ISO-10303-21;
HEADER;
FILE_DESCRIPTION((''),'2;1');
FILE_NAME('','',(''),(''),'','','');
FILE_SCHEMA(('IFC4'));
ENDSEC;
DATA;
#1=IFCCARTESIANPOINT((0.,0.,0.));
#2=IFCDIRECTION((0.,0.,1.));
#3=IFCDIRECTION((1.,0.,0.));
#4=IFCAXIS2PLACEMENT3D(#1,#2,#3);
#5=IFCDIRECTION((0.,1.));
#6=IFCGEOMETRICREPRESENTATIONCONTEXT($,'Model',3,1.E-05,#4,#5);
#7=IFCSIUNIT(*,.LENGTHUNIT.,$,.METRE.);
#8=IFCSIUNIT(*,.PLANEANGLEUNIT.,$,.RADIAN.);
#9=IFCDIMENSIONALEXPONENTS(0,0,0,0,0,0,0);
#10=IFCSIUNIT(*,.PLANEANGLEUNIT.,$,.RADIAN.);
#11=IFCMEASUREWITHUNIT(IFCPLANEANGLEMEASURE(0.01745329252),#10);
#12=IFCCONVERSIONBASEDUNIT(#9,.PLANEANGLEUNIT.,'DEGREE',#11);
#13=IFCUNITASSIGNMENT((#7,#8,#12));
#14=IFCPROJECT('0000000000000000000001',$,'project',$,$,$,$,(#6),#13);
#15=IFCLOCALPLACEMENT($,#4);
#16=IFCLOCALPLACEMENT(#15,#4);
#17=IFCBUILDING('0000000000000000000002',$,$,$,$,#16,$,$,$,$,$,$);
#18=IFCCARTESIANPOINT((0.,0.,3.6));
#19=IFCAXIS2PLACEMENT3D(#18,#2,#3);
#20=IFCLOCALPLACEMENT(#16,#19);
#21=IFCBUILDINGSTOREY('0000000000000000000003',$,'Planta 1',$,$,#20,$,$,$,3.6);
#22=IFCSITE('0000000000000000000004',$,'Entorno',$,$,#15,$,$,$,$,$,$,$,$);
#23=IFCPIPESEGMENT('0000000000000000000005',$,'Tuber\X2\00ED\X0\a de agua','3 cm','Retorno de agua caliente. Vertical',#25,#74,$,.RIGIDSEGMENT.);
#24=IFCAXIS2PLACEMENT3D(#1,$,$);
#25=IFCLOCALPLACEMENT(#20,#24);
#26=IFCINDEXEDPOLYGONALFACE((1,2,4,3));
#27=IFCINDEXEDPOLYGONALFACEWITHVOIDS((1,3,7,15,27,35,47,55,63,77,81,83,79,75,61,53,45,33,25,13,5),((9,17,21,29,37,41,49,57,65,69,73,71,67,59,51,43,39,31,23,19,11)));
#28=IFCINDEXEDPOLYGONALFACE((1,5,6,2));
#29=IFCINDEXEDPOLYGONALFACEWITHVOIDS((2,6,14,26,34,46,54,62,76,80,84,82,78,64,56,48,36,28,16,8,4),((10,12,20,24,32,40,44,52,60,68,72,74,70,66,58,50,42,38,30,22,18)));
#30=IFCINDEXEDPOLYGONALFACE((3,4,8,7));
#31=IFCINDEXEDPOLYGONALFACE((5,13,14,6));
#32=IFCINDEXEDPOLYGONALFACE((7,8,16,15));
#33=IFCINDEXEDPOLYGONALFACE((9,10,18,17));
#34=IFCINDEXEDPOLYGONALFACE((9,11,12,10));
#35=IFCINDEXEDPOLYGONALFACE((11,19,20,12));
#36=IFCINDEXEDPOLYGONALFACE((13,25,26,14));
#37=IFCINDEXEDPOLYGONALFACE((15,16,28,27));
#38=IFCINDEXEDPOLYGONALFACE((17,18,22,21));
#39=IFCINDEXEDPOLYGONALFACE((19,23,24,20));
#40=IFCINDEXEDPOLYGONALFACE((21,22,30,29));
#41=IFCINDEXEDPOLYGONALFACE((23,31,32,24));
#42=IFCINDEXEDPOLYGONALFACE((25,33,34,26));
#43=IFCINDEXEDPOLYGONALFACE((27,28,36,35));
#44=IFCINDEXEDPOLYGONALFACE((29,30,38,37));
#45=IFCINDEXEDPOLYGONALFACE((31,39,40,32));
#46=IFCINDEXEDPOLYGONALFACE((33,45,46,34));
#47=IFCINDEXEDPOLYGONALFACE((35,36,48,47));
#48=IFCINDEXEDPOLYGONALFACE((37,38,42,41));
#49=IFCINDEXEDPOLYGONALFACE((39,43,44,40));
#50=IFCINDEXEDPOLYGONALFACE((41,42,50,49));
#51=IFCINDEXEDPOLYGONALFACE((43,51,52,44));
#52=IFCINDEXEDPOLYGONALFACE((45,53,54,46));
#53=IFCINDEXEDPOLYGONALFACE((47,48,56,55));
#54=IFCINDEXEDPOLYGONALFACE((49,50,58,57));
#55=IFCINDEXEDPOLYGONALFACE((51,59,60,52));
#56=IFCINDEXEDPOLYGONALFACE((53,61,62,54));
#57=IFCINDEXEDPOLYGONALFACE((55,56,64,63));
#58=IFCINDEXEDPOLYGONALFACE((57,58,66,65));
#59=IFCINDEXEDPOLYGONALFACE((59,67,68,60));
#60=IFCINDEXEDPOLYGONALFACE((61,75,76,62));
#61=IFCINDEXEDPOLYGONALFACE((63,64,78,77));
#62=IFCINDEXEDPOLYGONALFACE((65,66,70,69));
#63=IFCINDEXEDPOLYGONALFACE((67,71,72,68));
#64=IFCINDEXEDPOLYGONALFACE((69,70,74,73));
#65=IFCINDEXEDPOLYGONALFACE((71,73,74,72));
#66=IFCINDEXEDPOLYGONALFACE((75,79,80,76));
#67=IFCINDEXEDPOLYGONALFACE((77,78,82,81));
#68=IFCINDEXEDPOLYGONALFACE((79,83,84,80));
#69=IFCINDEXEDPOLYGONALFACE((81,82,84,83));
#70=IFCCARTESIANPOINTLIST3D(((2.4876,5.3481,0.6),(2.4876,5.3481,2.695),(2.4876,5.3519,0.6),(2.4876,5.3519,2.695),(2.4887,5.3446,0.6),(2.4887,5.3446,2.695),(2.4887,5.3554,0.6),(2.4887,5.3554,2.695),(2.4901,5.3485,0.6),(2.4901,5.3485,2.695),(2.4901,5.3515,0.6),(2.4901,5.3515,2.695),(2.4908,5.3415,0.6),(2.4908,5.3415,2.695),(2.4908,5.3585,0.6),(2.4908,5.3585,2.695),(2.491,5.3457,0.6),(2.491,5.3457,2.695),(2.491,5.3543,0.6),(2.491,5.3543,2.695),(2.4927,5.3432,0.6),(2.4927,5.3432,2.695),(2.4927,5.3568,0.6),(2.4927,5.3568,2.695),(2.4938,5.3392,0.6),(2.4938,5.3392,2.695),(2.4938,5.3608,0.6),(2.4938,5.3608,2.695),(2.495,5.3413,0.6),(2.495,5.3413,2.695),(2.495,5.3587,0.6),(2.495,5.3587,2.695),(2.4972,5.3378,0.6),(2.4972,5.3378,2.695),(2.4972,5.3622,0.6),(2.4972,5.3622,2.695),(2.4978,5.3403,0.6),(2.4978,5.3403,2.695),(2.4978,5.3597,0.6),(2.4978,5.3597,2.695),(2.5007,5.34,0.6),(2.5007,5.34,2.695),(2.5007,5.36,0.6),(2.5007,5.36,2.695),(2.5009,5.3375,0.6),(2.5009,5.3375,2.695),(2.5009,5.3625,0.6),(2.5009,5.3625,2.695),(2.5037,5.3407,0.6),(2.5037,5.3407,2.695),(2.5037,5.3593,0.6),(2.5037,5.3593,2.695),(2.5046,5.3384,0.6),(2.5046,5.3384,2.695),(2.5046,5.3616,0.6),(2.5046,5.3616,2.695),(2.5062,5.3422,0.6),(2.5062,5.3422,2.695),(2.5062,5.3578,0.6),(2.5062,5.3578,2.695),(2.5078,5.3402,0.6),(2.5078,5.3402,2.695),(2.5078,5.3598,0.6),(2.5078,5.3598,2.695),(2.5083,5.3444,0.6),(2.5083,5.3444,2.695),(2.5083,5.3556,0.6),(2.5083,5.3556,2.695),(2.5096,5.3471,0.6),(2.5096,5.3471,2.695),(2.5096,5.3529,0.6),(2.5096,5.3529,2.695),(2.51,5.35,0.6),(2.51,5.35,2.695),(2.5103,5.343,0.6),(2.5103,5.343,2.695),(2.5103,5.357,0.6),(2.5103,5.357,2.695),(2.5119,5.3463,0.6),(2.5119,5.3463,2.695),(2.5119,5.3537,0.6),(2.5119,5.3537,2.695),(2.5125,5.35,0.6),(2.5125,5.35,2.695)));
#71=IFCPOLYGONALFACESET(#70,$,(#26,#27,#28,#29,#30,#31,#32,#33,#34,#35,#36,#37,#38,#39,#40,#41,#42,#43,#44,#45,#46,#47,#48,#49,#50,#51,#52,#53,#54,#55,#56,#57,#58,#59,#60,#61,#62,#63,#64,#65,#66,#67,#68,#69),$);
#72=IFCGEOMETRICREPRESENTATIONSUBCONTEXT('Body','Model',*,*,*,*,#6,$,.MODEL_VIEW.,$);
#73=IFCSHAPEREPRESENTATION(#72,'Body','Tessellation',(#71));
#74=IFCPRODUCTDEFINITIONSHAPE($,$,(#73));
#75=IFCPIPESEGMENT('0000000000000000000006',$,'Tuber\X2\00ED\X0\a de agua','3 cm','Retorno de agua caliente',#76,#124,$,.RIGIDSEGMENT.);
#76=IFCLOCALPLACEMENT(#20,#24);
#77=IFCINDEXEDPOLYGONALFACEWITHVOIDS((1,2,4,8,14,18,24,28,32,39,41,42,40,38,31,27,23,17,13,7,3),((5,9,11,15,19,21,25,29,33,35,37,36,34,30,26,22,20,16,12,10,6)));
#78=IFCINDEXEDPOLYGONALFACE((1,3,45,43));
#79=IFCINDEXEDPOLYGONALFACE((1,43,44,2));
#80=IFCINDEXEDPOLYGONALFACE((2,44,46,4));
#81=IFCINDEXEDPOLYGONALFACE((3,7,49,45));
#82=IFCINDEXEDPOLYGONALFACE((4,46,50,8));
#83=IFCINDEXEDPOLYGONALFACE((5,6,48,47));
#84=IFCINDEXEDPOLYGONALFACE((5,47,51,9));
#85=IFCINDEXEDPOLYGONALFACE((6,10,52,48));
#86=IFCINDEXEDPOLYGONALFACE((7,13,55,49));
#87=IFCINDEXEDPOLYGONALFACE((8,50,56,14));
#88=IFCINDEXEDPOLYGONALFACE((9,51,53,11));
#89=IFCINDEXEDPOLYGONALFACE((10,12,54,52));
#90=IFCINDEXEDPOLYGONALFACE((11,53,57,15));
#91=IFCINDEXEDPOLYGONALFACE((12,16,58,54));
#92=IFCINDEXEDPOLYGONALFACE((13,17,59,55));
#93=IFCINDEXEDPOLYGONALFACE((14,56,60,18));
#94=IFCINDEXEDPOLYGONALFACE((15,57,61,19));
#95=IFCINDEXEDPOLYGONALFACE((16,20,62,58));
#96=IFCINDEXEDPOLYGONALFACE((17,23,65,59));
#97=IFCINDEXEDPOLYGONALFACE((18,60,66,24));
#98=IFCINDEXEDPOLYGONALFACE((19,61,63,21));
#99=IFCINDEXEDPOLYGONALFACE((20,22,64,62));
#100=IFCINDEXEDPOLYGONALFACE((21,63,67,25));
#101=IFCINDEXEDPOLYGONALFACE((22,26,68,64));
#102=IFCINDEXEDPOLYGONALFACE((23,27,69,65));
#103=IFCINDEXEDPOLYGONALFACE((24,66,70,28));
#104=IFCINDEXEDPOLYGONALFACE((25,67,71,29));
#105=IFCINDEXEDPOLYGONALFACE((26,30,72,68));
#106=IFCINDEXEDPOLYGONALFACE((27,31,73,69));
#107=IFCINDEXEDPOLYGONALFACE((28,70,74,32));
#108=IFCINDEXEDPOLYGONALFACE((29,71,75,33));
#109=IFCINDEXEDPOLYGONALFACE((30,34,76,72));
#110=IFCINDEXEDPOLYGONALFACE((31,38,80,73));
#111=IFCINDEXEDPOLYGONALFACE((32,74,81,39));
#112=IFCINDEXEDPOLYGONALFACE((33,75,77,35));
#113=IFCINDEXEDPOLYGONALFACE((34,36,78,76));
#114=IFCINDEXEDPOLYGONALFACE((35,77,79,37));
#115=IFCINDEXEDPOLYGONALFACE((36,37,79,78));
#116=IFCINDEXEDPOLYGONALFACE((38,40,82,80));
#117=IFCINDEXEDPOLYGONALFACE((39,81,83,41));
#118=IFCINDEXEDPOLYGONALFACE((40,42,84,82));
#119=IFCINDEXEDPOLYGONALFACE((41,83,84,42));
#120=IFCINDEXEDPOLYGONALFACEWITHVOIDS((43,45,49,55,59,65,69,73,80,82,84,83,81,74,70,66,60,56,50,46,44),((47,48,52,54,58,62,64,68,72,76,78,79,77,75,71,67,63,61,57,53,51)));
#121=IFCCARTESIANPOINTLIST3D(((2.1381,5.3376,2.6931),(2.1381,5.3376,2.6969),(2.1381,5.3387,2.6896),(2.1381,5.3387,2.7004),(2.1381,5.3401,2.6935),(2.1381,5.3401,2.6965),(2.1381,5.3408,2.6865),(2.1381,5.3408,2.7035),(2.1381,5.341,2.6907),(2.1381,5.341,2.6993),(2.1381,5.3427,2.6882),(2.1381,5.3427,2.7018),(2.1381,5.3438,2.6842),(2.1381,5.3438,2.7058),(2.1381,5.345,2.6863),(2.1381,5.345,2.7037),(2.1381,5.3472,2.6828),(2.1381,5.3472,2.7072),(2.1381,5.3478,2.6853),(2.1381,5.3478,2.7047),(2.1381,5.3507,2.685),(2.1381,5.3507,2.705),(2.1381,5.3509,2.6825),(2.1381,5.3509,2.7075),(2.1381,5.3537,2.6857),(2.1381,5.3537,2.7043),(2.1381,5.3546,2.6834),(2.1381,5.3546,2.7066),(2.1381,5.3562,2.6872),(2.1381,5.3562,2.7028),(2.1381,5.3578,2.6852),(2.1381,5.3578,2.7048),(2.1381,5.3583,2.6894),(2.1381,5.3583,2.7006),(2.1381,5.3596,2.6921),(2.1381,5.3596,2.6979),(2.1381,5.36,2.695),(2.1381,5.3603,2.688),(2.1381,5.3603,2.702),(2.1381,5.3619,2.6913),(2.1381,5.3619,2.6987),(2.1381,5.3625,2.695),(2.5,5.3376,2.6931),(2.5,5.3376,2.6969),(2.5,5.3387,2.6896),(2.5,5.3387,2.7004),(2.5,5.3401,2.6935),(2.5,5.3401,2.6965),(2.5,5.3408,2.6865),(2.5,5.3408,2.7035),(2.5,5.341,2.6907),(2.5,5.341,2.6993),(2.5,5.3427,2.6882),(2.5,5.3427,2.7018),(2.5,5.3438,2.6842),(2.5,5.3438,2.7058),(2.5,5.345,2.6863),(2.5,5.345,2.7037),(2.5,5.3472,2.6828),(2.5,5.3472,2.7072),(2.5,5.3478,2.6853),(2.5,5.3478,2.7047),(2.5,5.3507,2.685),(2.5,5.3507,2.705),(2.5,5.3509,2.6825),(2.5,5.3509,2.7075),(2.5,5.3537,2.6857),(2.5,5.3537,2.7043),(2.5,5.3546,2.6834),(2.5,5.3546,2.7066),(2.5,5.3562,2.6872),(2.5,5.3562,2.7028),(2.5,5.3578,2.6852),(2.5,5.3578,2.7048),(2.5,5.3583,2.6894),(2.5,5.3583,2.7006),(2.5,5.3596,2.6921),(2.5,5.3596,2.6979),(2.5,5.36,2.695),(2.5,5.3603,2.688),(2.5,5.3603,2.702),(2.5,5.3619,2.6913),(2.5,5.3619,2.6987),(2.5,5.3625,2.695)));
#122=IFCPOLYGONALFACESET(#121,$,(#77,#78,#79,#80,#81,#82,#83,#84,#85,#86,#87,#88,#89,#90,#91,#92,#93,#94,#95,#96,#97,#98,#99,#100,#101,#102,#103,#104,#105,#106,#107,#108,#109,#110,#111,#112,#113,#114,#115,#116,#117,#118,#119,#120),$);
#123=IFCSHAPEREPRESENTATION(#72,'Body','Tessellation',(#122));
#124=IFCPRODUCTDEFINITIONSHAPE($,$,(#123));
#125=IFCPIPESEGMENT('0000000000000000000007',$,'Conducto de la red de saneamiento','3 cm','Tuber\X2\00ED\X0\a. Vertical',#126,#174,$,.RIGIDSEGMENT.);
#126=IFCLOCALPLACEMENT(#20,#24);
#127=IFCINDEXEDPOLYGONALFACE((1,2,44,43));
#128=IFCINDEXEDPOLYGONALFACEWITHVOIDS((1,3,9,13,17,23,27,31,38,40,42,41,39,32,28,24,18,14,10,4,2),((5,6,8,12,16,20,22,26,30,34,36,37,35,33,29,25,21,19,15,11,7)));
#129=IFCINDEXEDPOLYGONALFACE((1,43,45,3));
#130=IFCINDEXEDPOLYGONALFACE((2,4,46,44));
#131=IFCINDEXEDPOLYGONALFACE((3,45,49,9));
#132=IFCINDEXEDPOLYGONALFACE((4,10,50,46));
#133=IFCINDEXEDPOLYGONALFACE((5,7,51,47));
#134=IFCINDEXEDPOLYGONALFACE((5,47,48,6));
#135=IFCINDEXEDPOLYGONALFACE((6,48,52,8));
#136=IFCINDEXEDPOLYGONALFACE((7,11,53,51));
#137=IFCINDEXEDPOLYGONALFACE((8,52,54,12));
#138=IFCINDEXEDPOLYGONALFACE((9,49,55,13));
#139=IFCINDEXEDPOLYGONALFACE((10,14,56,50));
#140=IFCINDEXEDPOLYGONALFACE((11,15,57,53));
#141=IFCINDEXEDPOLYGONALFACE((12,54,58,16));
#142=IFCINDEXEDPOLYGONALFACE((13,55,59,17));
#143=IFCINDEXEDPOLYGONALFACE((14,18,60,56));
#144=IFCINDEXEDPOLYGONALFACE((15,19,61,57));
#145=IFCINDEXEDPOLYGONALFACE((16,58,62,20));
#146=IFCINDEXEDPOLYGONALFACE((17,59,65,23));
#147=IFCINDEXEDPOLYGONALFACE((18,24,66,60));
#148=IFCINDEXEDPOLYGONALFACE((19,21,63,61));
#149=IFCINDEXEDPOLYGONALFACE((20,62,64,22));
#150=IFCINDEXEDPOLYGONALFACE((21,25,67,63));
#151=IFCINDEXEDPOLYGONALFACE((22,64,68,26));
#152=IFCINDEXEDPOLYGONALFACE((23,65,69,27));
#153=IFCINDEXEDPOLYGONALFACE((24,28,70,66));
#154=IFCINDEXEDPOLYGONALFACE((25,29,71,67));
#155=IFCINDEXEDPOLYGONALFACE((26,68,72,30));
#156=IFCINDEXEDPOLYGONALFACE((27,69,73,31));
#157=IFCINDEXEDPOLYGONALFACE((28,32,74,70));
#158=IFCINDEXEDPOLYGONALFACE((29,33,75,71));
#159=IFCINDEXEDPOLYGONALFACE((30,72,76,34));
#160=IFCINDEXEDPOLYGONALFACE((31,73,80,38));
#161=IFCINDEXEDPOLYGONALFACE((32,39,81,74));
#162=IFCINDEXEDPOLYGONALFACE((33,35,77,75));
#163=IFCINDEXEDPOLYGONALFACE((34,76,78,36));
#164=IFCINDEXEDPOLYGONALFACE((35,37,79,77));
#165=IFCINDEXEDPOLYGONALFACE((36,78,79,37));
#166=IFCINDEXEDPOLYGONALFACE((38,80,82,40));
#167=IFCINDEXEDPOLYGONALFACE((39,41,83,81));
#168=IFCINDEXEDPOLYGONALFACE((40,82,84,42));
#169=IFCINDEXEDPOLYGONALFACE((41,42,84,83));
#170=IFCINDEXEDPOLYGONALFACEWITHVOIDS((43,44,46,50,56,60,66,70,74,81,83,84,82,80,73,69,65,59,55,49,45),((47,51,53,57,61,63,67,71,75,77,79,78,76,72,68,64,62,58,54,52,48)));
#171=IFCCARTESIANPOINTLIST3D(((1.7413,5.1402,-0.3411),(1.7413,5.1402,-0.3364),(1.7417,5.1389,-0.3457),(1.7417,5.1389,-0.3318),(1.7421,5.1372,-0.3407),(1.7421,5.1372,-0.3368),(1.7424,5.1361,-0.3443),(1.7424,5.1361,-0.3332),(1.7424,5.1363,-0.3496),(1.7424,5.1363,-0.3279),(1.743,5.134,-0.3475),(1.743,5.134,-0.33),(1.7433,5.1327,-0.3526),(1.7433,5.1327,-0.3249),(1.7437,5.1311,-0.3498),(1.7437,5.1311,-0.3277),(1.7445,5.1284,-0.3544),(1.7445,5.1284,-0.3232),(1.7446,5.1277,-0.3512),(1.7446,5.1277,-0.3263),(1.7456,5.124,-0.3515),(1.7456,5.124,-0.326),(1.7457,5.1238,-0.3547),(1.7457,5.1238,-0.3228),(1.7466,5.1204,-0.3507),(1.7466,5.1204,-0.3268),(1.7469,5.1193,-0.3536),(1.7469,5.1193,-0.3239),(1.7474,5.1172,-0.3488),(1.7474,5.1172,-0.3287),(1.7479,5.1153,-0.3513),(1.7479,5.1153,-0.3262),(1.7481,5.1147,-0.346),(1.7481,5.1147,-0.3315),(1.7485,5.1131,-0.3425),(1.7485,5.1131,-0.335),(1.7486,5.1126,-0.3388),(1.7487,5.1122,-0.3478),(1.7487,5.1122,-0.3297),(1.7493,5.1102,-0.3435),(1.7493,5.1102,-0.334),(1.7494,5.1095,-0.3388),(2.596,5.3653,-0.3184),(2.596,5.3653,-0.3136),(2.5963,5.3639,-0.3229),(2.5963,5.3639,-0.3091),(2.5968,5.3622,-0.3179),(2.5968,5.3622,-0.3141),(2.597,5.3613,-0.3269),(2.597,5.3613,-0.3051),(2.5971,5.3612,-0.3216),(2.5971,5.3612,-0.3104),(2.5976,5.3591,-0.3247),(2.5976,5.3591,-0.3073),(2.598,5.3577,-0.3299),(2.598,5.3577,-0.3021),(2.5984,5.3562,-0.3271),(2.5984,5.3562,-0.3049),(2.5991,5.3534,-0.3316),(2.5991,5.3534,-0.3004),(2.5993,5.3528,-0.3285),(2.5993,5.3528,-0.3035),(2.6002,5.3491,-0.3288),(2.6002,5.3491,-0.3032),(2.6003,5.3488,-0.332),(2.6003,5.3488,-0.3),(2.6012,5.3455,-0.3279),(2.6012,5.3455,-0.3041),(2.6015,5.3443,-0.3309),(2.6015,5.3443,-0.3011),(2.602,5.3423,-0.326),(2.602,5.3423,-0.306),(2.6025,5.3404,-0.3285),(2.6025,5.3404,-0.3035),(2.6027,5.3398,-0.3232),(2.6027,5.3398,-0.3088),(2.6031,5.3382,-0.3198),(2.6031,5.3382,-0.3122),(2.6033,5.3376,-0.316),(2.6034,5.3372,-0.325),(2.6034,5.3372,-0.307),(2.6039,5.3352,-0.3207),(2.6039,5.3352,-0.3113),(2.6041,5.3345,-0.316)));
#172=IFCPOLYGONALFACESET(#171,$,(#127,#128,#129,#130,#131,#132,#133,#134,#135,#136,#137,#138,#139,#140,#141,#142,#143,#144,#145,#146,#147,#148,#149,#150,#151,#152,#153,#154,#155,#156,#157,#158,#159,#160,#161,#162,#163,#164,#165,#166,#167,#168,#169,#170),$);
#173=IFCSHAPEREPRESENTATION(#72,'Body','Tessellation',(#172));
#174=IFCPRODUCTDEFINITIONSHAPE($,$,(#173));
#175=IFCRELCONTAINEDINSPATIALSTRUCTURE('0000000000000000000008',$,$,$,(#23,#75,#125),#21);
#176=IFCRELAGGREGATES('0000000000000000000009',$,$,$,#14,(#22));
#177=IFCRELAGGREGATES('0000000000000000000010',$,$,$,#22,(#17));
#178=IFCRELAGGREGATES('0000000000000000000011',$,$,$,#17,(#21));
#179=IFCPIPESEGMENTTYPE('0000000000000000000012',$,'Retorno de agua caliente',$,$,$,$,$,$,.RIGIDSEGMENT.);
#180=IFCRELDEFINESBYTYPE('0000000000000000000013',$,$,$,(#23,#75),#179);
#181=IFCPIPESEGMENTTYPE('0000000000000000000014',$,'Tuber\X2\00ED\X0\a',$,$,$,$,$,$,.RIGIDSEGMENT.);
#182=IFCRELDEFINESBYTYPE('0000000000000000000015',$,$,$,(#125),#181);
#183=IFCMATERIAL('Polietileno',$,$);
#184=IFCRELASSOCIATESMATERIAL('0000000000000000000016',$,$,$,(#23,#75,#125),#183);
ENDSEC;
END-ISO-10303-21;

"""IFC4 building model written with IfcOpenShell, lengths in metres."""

from ifc_helpers import new_model, entity, si_unit, converted_unit, direction, frame, origin_with_axes, origin_2d_with_axis, place, context, subcontext, project, spatial, hollow_circle, extrude, material, type_object, element, save


model = new_model("IFC4")

# Units and contexts
model_context = context("Model", 3, precision=1e-05, world=origin_with_axes(), true_north=direction((0.0, 1.0)))
body_context = subcontext(model_context, "Body", "Model", "MODEL_VIEW")
ifc_project = project(units=[si_unit("LENGTHUNIT", "METRE"), si_unit("PLANEANGLEUNIT", "RADIAN"), converted_unit("PLANEANGLEUNIT", "DEGREE", entity("IfcPlaneAngleMeasure", 0.01745329252), si_unit("PLANEANGLEUNIT", "RADIAN"), dimensions=[0, 0, 0, 0, 0, 0, 0])], contexts=[model_context])

# Site, building, storey
site_placement = place(None, origin_with_axes())
site = spatial("IfcSite", under=ifc_project, at=site_placement, Name="Entorno")
building_placement = place(site_placement, origin_with_axes())
building = spatial("IfcBuilding", under=site, at=building_placement)
storey_placement = place(building_placement, frame((0.0, 0.0, 3.6), z_axis=(0.0, 0.0, 1.0), x_axis=(1.0, 0.0, 0.0)))
storey = spatial("IfcBuildingStorey", under=building, at=storey_placement, Name="Planta 1", Elevation=3.6)

# Pipe segments
ifc_material_1 = material(Name="Polietileno")
pipe_segment_type_1 = type_object("IfcPipeSegmentType", Name="Retorno de agua caliente", PredefinedType="RIGIDSEGMENT")
pipe_segment_1_placement = place(storey_placement, frame((2.5, 5.35, 2.695), z_axis=(0.0, 0.0, -1.0), x_axis=(1.0, 0.0, 0.0)))
element("IfcPipeSegment", 1, at=pipe_segment_1_placement, inside=storey, type_object=pipe_segment_type_1, material=ifc_material_1, Name="Tubería de agua", Description="3 cm", ObjectType="Retorno de agua caliente. Vertical", PredefinedType="RIGIDSEGMENT", context=body_context, shape_type="SweptSolid", body=[
    extrude(hollow_circle(Radius=0.0125, WallThickness=0.0025, at=origin_2d_with_axis()), origin_with_axes(), (0.0, 0.0, 1.0), 2.095),
])
pipe_segment_2_placement = place(storey_placement, frame((2.1381, 5.35, 2.695), z_axis=(1.0, 0.0, 0.0), x_axis=(0.0, 1.0, 0.0)))
element("IfcPipeSegment", 2, at=pipe_segment_2_placement, inside=storey, type_object=pipe_segment_type_1, material=ifc_material_1, Name="Tubería de agua", Description="3 cm", ObjectType="Retorno de agua caliente", PredefinedType="RIGIDSEGMENT", context=body_context, shape_type="SweptSolid", body=[
    extrude(hollow_circle(Radius=0.0125, WallThickness=0.0025, at=origin_2d_with_axis()), origin_with_axes(), (0.0, 0.0, 1.0), 0.3619),
])
pipe_segment_type_2 = type_object("IfcPipeSegmentType", Name="Tubería", PredefinedType="RIGIDSEGMENT")
pipe_segment_3_placement = place(storey_placement, frame((2.6, 5.35, -0.316), z_axis=(-0.967031, -0.254657, 0.0), x_axis=(0.254657, -0.967031, 0.0)))
element("IfcPipeSegment", 3, at=pipe_segment_3_placement, inside=storey, type_object=pipe_segment_type_2, material=ifc_material_1, Name="Conducto de la red de saneamiento", Description="3 cm", ObjectType="Tubería. Vertical", PredefinedType="RIGIDSEGMENT", context=body_context, shape_type="SweptSolid", body=[
    extrude(hollow_circle(Radius=0.016, WallThickness=0.0032, at=origin_2d_with_axis()), origin_with_axes(), (0.0, -0.025735, 0.999669), 0.8841),
])

save(model, "model.ifc")
